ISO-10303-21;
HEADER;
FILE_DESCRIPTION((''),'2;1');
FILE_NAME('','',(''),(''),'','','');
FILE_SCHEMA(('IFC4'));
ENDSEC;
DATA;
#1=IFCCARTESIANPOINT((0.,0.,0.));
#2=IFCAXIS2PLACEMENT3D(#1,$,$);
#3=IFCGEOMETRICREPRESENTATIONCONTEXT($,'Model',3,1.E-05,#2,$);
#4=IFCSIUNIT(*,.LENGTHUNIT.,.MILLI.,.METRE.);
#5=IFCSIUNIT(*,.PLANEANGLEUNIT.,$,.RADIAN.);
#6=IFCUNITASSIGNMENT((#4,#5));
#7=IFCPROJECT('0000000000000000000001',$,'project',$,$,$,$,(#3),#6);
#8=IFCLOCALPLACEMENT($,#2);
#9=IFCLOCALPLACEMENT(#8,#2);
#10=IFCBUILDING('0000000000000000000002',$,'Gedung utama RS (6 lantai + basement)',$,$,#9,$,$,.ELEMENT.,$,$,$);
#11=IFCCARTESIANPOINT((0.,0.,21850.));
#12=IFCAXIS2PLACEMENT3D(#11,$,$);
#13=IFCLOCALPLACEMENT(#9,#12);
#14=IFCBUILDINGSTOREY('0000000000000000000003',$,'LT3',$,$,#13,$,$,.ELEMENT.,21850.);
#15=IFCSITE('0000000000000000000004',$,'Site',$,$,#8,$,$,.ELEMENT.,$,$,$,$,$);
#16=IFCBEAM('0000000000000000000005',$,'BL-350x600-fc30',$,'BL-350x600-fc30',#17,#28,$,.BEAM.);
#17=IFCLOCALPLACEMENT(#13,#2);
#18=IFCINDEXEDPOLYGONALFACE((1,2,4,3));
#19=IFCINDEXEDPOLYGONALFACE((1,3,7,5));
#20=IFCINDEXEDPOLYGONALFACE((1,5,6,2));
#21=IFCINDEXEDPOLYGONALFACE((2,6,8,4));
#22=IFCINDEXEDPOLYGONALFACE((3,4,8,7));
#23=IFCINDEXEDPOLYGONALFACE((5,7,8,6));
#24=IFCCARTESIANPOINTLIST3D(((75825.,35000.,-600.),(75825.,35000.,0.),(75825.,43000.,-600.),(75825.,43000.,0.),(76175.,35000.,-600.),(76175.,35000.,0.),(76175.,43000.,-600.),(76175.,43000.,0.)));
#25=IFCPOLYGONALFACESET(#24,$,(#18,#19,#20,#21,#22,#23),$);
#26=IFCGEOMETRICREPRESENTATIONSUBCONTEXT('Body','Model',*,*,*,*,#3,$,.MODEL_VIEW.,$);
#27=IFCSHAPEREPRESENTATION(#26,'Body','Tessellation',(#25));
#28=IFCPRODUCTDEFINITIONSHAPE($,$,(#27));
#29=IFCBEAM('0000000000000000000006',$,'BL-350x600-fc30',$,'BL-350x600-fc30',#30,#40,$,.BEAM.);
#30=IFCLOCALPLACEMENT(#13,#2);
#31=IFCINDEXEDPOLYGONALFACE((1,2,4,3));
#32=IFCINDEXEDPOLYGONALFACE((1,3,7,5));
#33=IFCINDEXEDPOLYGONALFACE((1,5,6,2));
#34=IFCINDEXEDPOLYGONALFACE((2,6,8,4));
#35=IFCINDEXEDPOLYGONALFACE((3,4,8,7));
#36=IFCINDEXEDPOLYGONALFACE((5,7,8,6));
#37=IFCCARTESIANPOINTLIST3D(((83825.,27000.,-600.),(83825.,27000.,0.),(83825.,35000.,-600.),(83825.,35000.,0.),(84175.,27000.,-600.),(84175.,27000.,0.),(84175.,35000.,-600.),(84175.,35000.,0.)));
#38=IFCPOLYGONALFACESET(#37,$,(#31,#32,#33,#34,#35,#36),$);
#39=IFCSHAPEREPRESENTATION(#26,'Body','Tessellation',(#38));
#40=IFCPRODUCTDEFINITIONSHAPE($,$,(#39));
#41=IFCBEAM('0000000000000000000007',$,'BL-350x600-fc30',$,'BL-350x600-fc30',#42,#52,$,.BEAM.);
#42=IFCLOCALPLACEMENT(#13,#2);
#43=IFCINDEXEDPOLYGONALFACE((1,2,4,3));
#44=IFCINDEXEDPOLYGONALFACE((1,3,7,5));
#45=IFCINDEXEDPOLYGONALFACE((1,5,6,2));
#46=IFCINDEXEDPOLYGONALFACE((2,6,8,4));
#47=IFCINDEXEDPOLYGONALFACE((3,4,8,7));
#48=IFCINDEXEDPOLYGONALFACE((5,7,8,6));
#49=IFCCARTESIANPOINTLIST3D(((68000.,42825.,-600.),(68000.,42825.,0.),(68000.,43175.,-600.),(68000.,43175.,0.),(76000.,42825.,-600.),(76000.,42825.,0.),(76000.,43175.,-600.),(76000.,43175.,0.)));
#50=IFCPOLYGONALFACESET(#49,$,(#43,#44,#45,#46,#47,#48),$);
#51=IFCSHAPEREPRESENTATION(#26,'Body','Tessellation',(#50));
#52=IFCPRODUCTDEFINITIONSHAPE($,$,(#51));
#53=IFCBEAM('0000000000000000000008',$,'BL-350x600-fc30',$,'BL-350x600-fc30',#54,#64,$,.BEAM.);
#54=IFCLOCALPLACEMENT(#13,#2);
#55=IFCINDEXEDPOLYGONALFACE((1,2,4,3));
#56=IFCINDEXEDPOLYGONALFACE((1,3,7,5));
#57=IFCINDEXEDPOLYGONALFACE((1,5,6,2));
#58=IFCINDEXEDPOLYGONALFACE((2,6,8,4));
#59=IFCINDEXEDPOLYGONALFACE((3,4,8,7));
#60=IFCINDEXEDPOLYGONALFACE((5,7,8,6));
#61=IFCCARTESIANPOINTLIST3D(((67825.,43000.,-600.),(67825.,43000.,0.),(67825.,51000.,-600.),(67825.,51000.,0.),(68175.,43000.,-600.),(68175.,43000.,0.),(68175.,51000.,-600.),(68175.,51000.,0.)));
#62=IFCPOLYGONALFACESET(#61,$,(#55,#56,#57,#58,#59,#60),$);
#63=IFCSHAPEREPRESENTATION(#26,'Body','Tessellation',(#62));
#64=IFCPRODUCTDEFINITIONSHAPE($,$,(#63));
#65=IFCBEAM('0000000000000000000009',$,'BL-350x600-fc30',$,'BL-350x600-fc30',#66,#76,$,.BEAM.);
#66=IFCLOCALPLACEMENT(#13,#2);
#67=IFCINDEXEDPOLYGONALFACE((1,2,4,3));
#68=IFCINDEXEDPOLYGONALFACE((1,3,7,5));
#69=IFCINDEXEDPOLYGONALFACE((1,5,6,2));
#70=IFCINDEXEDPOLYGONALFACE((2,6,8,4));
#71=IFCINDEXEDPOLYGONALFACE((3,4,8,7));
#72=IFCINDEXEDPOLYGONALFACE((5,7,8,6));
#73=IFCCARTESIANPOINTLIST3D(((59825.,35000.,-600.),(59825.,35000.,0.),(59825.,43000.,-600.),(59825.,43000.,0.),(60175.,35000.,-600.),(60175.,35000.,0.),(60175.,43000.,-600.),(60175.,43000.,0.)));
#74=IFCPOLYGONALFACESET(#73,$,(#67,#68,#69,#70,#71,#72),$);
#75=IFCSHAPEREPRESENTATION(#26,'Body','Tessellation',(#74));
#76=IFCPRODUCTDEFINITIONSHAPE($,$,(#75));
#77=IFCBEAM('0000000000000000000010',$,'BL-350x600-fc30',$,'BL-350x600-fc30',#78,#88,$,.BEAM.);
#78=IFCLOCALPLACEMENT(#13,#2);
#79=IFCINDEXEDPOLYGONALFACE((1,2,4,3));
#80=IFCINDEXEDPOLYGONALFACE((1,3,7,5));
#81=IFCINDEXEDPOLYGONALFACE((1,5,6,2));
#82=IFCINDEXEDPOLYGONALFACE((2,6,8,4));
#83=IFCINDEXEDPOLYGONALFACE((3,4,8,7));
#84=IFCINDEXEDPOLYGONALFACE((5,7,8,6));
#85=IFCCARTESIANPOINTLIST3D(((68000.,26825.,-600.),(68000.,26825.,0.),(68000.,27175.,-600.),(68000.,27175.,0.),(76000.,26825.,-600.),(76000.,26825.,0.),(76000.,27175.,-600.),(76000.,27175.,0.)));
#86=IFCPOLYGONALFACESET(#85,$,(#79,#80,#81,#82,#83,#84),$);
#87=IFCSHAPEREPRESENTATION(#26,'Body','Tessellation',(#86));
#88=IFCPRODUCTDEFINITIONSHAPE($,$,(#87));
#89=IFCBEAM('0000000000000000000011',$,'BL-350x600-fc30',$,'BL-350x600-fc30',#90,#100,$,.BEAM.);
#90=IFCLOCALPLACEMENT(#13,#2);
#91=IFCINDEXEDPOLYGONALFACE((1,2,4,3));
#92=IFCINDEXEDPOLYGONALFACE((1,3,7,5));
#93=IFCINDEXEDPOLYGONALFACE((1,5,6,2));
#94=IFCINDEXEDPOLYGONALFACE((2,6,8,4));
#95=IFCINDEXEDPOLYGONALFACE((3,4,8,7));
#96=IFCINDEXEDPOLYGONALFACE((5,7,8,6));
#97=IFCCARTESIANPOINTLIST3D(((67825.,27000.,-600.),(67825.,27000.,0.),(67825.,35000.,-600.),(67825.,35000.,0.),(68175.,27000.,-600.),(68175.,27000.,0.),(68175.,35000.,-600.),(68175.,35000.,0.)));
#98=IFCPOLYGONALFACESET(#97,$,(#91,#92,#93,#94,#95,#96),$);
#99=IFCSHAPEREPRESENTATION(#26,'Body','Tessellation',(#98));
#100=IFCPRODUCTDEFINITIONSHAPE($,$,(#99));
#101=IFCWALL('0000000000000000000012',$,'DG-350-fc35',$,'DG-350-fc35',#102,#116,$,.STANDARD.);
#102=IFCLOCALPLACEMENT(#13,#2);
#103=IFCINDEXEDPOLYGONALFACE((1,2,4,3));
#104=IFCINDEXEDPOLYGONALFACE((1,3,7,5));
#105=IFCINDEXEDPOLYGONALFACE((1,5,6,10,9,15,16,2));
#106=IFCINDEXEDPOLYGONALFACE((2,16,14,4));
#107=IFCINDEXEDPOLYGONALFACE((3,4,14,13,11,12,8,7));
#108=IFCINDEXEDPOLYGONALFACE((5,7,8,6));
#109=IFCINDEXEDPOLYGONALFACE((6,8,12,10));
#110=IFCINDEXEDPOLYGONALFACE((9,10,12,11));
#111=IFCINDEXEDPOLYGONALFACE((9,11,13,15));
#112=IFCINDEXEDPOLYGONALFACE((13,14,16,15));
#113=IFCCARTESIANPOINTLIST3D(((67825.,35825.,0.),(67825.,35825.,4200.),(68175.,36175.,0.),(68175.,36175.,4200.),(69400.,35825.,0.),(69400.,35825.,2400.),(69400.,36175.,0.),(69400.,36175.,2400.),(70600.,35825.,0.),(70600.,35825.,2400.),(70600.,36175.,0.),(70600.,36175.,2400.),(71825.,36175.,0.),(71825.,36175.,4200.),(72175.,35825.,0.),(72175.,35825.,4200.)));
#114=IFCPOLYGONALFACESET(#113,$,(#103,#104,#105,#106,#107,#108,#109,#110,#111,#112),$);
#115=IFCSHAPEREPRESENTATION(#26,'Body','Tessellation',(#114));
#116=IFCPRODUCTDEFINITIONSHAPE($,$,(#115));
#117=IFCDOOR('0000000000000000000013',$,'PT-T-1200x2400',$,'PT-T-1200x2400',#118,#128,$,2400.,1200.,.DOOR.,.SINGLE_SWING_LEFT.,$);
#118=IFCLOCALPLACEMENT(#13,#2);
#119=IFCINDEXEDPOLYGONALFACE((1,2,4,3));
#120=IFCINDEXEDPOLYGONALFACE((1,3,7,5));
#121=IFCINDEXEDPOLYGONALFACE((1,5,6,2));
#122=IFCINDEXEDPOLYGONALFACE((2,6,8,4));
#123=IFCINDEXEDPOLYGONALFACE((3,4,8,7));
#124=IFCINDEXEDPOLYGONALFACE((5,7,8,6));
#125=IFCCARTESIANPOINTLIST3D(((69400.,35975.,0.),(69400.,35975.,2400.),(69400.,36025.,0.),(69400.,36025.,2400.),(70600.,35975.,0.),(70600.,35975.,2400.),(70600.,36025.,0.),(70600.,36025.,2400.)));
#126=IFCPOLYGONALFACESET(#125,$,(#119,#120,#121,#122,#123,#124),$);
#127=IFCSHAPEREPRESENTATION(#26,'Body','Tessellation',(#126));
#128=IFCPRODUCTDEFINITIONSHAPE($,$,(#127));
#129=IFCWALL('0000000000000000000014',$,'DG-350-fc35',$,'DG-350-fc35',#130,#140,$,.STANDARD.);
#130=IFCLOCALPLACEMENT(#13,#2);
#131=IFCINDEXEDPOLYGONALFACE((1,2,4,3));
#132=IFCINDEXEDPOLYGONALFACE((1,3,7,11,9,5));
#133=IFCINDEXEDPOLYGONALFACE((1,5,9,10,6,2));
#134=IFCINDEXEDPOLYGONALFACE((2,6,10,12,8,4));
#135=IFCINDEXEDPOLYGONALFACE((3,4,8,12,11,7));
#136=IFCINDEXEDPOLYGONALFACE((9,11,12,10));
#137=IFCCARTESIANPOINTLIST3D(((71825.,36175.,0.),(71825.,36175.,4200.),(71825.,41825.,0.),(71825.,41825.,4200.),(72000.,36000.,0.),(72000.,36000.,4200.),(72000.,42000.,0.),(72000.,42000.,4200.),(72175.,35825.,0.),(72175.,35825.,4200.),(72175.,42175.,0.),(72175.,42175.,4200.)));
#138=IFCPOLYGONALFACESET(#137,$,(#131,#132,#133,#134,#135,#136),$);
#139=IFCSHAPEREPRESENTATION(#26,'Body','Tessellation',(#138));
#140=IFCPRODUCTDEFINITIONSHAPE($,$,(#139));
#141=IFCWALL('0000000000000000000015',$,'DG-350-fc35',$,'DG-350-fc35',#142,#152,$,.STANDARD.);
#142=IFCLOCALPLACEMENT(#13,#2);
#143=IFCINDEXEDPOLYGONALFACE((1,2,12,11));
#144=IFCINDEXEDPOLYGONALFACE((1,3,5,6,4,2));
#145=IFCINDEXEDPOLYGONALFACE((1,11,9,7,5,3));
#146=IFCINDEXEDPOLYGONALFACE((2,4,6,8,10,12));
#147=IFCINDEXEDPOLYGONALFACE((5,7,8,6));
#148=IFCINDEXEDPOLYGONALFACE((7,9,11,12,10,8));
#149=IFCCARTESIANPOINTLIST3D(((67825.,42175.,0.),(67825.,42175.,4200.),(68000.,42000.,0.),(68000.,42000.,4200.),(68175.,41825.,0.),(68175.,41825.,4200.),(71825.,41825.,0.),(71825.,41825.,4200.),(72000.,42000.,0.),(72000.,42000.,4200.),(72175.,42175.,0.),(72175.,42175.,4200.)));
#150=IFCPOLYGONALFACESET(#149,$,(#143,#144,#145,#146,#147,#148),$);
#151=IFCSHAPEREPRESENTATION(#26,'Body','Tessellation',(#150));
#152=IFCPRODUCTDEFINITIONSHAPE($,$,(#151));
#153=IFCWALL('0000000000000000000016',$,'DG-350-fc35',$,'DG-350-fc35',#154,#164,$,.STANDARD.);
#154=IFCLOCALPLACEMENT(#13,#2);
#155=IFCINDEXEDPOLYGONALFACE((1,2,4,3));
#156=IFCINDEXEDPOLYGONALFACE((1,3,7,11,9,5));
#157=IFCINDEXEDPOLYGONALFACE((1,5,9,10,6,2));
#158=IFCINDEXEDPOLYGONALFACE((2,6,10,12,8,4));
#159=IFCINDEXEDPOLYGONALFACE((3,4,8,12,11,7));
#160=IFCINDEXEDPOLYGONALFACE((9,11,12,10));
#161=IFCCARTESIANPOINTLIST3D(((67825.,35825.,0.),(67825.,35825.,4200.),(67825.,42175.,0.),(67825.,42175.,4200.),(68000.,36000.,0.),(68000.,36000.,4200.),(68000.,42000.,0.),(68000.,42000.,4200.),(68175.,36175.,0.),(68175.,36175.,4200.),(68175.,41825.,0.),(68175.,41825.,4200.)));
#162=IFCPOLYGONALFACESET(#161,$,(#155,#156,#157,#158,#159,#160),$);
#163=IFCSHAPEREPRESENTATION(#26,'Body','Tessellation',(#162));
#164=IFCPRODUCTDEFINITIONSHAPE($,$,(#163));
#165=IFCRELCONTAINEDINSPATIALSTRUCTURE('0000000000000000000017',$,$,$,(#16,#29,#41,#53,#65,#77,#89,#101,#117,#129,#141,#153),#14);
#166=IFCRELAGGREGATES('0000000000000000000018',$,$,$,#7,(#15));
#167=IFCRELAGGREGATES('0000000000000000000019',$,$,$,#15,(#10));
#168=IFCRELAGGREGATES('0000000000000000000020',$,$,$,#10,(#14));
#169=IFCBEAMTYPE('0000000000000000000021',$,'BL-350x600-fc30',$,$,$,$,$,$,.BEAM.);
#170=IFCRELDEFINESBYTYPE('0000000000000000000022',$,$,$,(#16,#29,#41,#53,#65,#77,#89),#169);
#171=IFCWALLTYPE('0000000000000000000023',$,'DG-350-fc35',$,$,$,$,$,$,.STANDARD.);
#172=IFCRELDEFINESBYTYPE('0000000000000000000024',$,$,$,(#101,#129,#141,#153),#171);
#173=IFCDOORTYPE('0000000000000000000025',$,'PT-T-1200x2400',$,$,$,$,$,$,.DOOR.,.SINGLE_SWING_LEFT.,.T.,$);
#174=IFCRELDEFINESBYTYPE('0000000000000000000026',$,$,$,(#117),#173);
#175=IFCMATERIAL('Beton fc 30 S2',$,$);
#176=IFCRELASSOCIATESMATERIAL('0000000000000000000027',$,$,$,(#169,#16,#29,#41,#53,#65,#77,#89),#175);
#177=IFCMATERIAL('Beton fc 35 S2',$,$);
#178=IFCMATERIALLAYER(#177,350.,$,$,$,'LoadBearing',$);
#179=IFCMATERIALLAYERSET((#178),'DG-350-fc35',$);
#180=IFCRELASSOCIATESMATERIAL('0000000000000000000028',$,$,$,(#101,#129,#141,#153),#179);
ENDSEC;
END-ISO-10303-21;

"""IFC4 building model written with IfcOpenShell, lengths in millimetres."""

from ifc_helpers import new_model, si_unit, frame, frame_2d, origin, origin_2d, place, context, subcontext, project, spatial, polyline, rectangle, outline, extrude, material, layer, layer_set, layer_usage, material_profile, profile_set, profile_usage, type_object, element, fill, save


model = new_model("IFC4")

# Units and contexts
model_context = context("Model", 3, precision=1e-05, world=origin())
body_context = subcontext(model_context, "Body", "Model", "MODEL_VIEW")
ifc_project = project(units=[si_unit("LENGTHUNIT", "METRE", prefix="MILLI"), si_unit("PLANEANGLEUNIT", "RADIAN")], contexts=[model_context])

# Site, building, storey
site_placement = place(None, origin())
site = spatial("IfcSite", under=ifc_project, at=site_placement, Name="Site", CompositionType="ELEMENT")
building_placement = place(site_placement, origin())
building = spatial("IfcBuilding", under=site, at=building_placement, Name="Gedung utama RS (6 lantai + basement)", CompositionType="ELEMENT")
storey_placement = place(building_placement, frame((0.0, 0.0, 21850.0)))
storey = spatial("IfcBuildingStorey", under=building, at=storey_placement, Name="LT3", CompositionType="ELEMENT", Elevation=21850.0)

# Beams
ifc_material_1 = material(Name="Beton fc 30 S2")
ifc_material_profile_1 = material_profile(ifc_material_1, rectangle(XDim=350.0, YDim=600.0, at=origin_2d()), Name="BL-350x600-fc30")
ifc_profile_set_1 = profile_set([ifc_material_profile_1], Name="BL-350x600-fc30")
ifc_profile_usage_1 = profile_usage(ifc_profile_set_1, cardinal=8)
beam_type = type_object("IfcBeamType", Name="BL-350x600-fc30", PredefinedType="BEAM", material=ifc_profile_set_1)
for number, where, name in (
    (1, (76000.0, 35000.0, -300.0), "BL-350x600-fc30"),
    (2, (84000.0, 27000.0, -300.0), "BL-350x600-fc30"),
):
    element("IfcBeam", number, at=place(storey_placement, frame(where)), inside=storey, type_object=beam_type, material=ifc_profile_usage_1, Name=name, ObjectType="BL-350x600-fc30", PredefinedType="BEAM", context=body_context, shape_type="SweptSolid", body=[
        extrude(rectangle(XDim=350.0, YDim=600.0, at=origin_2d()), frame((0.0, 0.0, 0.0), z_axis=(0.0, 1.0, 0.0), x_axis=(-1.0, 0.0, 0.0)), (0.0, 0.0, 1.0), 8000.0),
    ])
beam_1_placement = place(storey_placement, frame((68000.0, 43000.0, -300.0)))
element("IfcBeam", 3, at=beam_1_placement, inside=storey, type_object=beam_type, material=ifc_profile_usage_1, Name="BL-350x600-fc30", ObjectType="BL-350x600-fc30", PredefinedType="BEAM", context=body_context, shape_type="SweptSolid", body=[
    extrude(rectangle(XDim=350.0, YDim=600.0, at=origin_2d()), frame((0.0, 0.0, 0.0), z_axis=(1.0, 0.0, 0.0), x_axis=(0.0, 1.0, 0.0)), (0.0, 0.0, 1.0), 8000.0),
])
for number, where, name in (
    (4, (68000.0, 43000.0, -300.0), "BL-350x600-fc30"),
    (5, (60000.0, 35000.0, -300.0), "BL-350x600-fc30"),
):
    element("IfcBeam", number, at=place(storey_placement, frame(where)), inside=storey, type_object=beam_type, material=ifc_profile_usage_1, Name=name, ObjectType="BL-350x600-fc30", PredefinedType="BEAM", context=body_context, shape_type="SweptSolid", body=[
        extrude(rectangle(XDim=350.0, YDim=600.0, at=origin_2d()), frame((0.0, 0.0, 0.0), z_axis=(0.0, 1.0, 0.0), x_axis=(-1.0, 0.0, 0.0)), (0.0, 0.0, 1.0), 8000.0),
    ])
beam_2_placement = place(storey_placement, frame((68000.0, 27000.0, -300.0)))
element("IfcBeam", 6, at=beam_2_placement, inside=storey, type_object=beam_type, material=ifc_profile_usage_1, Name="BL-350x600-fc30", ObjectType="BL-350x600-fc30", PredefinedType="BEAM", context=body_context, shape_type="SweptSolid", body=[
    extrude(rectangle(XDim=350.0, YDim=600.0, at=origin_2d()), frame((0.0, 0.0, 0.0), z_axis=(1.0, 0.0, 0.0), x_axis=(0.0, 1.0, 0.0)), (0.0, 0.0, 1.0), 8000.0),
])
beam_3_placement = place(storey_placement, frame((68000.0, 27000.0, -300.0)))
element("IfcBeam", 7, at=beam_3_placement, inside=storey, type_object=beam_type, material=ifc_profile_usage_1, Name="BL-350x600-fc30", ObjectType="BL-350x600-fc30", PredefinedType="BEAM", context=body_context, shape_type="SweptSolid", body=[
    extrude(rectangle(XDim=350.0, YDim=600.0, at=origin_2d()), frame((0.0, 0.0, 0.0), z_axis=(0.0, 1.0, 0.0), x_axis=(-1.0, 0.0, 0.0)), (0.0, 0.0, 1.0), 8000.0),
])

# Wall, opening, door
ifc_material_2 = material(Name="Beton fc 35 S2")
ifc_layer = layer(ifc_material_2, 350.0, Category="LoadBearing")
ifc_layer_set = layer_set([ifc_layer], Name="DG-350-fc35")
ifc_layer_usage = layer_usage(ifc_layer_set, "AXIS2", "NEGATIVE", 175.0)
wall_type = type_object("IfcWallType", Name="DG-350-fc35", PredefinedType="STANDARD")
wall_1_placement = place(storey_placement, frame((68000.0, 36000.0, 0.0), z_axis=(0.0, 0.0, 1.0), x_axis=(1.0, 0.0, 0.0)))
wall_1 = element("IfcWall", 8, at=wall_1_placement, inside=storey, type_object=wall_type, material=ifc_layer_usage, Name="DG-350-fc35", ObjectType="DG-350-fc35", PredefinedType="STANDARD", context=body_context, shape_type="SweptSolid", body=[
    extrude(outline(polyline([(-175.0, -175.0), (0.0, 0.0), (175.0, 175.0), (3825.0, 175.0), (4000.0, 0.0), (4175.0, -175.0), (-175.0, -175.0)])), origin(), (0.0, 0.0, 1.0), 4200.0),
])
opening_placement = place(wall_1_placement, frame((1400.0, 0.0, 0.0), z_axis=(0.0, 0.0, 1.0), x_axis=(1.0, 0.0, 0.0)))
opening = element("IfcOpeningElement", 9, at=opening_placement, cuts=wall_1, PredefinedType="OPENING", context=body_context, shape_type="SweptSolid", body=[
    extrude(rectangle(XDim=1200.0, YDim=370.0, at=frame_2d((600.0, 0.0))), origin(), (0.0, 0.0, 1.0), 2400.0),
])
door_type = type_object("IfcDoorType", Name="PT-T-1200x2400", OperationType="SINGLE_SWING_LEFT", ParameterTakesPrecedence=True, PredefinedType="DOOR")
door_placement = place(opening_placement, origin())
door = element("IfcDoor", 10, at=door_placement, inside=storey, type_object=door_type, Name="PT-T-1200x2400", ObjectType="PT-T-1200x2400", OperationType="SINGLE_SWING_LEFT", OverallHeight=2400.0, OverallWidth=1200.0, PredefinedType="DOOR", context=body_context, shape_type="SweptSolid", body=[
    extrude(rectangle(XDim=1200.0, YDim=50.0, at=frame_2d((600.0, 0.0))), origin(), (0.0, 0.0, 1.0), 2400.0),
])
fill(opening, door)

# Walls
wall_2_placement = place(storey_placement, frame((72000.0, 36000.0, 0.0), z_axis=(0.0, 0.0, 1.0), x_axis=(0.0, 1.0, 0.0)))
element("IfcWall", 11, at=wall_2_placement, inside=storey, type_object=wall_type, material=ifc_layer_usage, Name="DG-350-fc35", ObjectType="DG-350-fc35", PredefinedType="STANDARD", context=body_context, shape_type="SweptSolid", body=[
    extrude(outline(polyline([(-175.0, -175.0), (0.0, 0.0), (175.0, 175.0), (5825.0, 175.0), (6000.0, 0.0), (6175.0, -175.0), (-175.0, -175.0)])), origin(), (0.0, 0.0, 1.0), 4200.0),
])
wall_3_placement = place(storey_placement, frame((72000.0, 42000.0, 0.0), z_axis=(0.0, 0.0, 1.0), x_axis=(-1.0, 0.0, 0.0)))
element("IfcWall", 12, at=wall_3_placement, inside=storey, type_object=wall_type, material=ifc_layer_usage, Name="DG-350-fc35", ObjectType="DG-350-fc35", PredefinedType="STANDARD", context=body_context, shape_type="SweptSolid", body=[
    extrude(outline(polyline([(-175.0, -175.0), (0.0, 0.0), (175.0, 175.0), (3825.0, 175.0), (4000.0, 0.0), (4175.0, -175.0), (-175.0, -175.0)])), origin(), (0.0, 0.0, 1.0), 4200.0),
])
wall_4_placement = place(storey_placement, frame((68000.0, 42000.0, 0.0), z_axis=(0.0, 0.0, 1.0), x_axis=(0.0, -1.0, 0.0)))
element("IfcWall", 13, at=wall_4_placement, inside=storey, type_object=wall_type, material=ifc_layer_usage, Name="DG-350-fc35", ObjectType="DG-350-fc35", PredefinedType="STANDARD", context=body_context, shape_type="SweptSolid", body=[
    extrude(outline(polyline([(-175.0, -175.0), (0.0, 0.0), (175.0, 175.0), (5825.0, 175.0), (6000.0, 0.0), (6175.0, -175.0), (-175.0, -175.0)])), origin(), (0.0, 0.0, 1.0), 4200.0),
])

save(model, "model.ifc")
